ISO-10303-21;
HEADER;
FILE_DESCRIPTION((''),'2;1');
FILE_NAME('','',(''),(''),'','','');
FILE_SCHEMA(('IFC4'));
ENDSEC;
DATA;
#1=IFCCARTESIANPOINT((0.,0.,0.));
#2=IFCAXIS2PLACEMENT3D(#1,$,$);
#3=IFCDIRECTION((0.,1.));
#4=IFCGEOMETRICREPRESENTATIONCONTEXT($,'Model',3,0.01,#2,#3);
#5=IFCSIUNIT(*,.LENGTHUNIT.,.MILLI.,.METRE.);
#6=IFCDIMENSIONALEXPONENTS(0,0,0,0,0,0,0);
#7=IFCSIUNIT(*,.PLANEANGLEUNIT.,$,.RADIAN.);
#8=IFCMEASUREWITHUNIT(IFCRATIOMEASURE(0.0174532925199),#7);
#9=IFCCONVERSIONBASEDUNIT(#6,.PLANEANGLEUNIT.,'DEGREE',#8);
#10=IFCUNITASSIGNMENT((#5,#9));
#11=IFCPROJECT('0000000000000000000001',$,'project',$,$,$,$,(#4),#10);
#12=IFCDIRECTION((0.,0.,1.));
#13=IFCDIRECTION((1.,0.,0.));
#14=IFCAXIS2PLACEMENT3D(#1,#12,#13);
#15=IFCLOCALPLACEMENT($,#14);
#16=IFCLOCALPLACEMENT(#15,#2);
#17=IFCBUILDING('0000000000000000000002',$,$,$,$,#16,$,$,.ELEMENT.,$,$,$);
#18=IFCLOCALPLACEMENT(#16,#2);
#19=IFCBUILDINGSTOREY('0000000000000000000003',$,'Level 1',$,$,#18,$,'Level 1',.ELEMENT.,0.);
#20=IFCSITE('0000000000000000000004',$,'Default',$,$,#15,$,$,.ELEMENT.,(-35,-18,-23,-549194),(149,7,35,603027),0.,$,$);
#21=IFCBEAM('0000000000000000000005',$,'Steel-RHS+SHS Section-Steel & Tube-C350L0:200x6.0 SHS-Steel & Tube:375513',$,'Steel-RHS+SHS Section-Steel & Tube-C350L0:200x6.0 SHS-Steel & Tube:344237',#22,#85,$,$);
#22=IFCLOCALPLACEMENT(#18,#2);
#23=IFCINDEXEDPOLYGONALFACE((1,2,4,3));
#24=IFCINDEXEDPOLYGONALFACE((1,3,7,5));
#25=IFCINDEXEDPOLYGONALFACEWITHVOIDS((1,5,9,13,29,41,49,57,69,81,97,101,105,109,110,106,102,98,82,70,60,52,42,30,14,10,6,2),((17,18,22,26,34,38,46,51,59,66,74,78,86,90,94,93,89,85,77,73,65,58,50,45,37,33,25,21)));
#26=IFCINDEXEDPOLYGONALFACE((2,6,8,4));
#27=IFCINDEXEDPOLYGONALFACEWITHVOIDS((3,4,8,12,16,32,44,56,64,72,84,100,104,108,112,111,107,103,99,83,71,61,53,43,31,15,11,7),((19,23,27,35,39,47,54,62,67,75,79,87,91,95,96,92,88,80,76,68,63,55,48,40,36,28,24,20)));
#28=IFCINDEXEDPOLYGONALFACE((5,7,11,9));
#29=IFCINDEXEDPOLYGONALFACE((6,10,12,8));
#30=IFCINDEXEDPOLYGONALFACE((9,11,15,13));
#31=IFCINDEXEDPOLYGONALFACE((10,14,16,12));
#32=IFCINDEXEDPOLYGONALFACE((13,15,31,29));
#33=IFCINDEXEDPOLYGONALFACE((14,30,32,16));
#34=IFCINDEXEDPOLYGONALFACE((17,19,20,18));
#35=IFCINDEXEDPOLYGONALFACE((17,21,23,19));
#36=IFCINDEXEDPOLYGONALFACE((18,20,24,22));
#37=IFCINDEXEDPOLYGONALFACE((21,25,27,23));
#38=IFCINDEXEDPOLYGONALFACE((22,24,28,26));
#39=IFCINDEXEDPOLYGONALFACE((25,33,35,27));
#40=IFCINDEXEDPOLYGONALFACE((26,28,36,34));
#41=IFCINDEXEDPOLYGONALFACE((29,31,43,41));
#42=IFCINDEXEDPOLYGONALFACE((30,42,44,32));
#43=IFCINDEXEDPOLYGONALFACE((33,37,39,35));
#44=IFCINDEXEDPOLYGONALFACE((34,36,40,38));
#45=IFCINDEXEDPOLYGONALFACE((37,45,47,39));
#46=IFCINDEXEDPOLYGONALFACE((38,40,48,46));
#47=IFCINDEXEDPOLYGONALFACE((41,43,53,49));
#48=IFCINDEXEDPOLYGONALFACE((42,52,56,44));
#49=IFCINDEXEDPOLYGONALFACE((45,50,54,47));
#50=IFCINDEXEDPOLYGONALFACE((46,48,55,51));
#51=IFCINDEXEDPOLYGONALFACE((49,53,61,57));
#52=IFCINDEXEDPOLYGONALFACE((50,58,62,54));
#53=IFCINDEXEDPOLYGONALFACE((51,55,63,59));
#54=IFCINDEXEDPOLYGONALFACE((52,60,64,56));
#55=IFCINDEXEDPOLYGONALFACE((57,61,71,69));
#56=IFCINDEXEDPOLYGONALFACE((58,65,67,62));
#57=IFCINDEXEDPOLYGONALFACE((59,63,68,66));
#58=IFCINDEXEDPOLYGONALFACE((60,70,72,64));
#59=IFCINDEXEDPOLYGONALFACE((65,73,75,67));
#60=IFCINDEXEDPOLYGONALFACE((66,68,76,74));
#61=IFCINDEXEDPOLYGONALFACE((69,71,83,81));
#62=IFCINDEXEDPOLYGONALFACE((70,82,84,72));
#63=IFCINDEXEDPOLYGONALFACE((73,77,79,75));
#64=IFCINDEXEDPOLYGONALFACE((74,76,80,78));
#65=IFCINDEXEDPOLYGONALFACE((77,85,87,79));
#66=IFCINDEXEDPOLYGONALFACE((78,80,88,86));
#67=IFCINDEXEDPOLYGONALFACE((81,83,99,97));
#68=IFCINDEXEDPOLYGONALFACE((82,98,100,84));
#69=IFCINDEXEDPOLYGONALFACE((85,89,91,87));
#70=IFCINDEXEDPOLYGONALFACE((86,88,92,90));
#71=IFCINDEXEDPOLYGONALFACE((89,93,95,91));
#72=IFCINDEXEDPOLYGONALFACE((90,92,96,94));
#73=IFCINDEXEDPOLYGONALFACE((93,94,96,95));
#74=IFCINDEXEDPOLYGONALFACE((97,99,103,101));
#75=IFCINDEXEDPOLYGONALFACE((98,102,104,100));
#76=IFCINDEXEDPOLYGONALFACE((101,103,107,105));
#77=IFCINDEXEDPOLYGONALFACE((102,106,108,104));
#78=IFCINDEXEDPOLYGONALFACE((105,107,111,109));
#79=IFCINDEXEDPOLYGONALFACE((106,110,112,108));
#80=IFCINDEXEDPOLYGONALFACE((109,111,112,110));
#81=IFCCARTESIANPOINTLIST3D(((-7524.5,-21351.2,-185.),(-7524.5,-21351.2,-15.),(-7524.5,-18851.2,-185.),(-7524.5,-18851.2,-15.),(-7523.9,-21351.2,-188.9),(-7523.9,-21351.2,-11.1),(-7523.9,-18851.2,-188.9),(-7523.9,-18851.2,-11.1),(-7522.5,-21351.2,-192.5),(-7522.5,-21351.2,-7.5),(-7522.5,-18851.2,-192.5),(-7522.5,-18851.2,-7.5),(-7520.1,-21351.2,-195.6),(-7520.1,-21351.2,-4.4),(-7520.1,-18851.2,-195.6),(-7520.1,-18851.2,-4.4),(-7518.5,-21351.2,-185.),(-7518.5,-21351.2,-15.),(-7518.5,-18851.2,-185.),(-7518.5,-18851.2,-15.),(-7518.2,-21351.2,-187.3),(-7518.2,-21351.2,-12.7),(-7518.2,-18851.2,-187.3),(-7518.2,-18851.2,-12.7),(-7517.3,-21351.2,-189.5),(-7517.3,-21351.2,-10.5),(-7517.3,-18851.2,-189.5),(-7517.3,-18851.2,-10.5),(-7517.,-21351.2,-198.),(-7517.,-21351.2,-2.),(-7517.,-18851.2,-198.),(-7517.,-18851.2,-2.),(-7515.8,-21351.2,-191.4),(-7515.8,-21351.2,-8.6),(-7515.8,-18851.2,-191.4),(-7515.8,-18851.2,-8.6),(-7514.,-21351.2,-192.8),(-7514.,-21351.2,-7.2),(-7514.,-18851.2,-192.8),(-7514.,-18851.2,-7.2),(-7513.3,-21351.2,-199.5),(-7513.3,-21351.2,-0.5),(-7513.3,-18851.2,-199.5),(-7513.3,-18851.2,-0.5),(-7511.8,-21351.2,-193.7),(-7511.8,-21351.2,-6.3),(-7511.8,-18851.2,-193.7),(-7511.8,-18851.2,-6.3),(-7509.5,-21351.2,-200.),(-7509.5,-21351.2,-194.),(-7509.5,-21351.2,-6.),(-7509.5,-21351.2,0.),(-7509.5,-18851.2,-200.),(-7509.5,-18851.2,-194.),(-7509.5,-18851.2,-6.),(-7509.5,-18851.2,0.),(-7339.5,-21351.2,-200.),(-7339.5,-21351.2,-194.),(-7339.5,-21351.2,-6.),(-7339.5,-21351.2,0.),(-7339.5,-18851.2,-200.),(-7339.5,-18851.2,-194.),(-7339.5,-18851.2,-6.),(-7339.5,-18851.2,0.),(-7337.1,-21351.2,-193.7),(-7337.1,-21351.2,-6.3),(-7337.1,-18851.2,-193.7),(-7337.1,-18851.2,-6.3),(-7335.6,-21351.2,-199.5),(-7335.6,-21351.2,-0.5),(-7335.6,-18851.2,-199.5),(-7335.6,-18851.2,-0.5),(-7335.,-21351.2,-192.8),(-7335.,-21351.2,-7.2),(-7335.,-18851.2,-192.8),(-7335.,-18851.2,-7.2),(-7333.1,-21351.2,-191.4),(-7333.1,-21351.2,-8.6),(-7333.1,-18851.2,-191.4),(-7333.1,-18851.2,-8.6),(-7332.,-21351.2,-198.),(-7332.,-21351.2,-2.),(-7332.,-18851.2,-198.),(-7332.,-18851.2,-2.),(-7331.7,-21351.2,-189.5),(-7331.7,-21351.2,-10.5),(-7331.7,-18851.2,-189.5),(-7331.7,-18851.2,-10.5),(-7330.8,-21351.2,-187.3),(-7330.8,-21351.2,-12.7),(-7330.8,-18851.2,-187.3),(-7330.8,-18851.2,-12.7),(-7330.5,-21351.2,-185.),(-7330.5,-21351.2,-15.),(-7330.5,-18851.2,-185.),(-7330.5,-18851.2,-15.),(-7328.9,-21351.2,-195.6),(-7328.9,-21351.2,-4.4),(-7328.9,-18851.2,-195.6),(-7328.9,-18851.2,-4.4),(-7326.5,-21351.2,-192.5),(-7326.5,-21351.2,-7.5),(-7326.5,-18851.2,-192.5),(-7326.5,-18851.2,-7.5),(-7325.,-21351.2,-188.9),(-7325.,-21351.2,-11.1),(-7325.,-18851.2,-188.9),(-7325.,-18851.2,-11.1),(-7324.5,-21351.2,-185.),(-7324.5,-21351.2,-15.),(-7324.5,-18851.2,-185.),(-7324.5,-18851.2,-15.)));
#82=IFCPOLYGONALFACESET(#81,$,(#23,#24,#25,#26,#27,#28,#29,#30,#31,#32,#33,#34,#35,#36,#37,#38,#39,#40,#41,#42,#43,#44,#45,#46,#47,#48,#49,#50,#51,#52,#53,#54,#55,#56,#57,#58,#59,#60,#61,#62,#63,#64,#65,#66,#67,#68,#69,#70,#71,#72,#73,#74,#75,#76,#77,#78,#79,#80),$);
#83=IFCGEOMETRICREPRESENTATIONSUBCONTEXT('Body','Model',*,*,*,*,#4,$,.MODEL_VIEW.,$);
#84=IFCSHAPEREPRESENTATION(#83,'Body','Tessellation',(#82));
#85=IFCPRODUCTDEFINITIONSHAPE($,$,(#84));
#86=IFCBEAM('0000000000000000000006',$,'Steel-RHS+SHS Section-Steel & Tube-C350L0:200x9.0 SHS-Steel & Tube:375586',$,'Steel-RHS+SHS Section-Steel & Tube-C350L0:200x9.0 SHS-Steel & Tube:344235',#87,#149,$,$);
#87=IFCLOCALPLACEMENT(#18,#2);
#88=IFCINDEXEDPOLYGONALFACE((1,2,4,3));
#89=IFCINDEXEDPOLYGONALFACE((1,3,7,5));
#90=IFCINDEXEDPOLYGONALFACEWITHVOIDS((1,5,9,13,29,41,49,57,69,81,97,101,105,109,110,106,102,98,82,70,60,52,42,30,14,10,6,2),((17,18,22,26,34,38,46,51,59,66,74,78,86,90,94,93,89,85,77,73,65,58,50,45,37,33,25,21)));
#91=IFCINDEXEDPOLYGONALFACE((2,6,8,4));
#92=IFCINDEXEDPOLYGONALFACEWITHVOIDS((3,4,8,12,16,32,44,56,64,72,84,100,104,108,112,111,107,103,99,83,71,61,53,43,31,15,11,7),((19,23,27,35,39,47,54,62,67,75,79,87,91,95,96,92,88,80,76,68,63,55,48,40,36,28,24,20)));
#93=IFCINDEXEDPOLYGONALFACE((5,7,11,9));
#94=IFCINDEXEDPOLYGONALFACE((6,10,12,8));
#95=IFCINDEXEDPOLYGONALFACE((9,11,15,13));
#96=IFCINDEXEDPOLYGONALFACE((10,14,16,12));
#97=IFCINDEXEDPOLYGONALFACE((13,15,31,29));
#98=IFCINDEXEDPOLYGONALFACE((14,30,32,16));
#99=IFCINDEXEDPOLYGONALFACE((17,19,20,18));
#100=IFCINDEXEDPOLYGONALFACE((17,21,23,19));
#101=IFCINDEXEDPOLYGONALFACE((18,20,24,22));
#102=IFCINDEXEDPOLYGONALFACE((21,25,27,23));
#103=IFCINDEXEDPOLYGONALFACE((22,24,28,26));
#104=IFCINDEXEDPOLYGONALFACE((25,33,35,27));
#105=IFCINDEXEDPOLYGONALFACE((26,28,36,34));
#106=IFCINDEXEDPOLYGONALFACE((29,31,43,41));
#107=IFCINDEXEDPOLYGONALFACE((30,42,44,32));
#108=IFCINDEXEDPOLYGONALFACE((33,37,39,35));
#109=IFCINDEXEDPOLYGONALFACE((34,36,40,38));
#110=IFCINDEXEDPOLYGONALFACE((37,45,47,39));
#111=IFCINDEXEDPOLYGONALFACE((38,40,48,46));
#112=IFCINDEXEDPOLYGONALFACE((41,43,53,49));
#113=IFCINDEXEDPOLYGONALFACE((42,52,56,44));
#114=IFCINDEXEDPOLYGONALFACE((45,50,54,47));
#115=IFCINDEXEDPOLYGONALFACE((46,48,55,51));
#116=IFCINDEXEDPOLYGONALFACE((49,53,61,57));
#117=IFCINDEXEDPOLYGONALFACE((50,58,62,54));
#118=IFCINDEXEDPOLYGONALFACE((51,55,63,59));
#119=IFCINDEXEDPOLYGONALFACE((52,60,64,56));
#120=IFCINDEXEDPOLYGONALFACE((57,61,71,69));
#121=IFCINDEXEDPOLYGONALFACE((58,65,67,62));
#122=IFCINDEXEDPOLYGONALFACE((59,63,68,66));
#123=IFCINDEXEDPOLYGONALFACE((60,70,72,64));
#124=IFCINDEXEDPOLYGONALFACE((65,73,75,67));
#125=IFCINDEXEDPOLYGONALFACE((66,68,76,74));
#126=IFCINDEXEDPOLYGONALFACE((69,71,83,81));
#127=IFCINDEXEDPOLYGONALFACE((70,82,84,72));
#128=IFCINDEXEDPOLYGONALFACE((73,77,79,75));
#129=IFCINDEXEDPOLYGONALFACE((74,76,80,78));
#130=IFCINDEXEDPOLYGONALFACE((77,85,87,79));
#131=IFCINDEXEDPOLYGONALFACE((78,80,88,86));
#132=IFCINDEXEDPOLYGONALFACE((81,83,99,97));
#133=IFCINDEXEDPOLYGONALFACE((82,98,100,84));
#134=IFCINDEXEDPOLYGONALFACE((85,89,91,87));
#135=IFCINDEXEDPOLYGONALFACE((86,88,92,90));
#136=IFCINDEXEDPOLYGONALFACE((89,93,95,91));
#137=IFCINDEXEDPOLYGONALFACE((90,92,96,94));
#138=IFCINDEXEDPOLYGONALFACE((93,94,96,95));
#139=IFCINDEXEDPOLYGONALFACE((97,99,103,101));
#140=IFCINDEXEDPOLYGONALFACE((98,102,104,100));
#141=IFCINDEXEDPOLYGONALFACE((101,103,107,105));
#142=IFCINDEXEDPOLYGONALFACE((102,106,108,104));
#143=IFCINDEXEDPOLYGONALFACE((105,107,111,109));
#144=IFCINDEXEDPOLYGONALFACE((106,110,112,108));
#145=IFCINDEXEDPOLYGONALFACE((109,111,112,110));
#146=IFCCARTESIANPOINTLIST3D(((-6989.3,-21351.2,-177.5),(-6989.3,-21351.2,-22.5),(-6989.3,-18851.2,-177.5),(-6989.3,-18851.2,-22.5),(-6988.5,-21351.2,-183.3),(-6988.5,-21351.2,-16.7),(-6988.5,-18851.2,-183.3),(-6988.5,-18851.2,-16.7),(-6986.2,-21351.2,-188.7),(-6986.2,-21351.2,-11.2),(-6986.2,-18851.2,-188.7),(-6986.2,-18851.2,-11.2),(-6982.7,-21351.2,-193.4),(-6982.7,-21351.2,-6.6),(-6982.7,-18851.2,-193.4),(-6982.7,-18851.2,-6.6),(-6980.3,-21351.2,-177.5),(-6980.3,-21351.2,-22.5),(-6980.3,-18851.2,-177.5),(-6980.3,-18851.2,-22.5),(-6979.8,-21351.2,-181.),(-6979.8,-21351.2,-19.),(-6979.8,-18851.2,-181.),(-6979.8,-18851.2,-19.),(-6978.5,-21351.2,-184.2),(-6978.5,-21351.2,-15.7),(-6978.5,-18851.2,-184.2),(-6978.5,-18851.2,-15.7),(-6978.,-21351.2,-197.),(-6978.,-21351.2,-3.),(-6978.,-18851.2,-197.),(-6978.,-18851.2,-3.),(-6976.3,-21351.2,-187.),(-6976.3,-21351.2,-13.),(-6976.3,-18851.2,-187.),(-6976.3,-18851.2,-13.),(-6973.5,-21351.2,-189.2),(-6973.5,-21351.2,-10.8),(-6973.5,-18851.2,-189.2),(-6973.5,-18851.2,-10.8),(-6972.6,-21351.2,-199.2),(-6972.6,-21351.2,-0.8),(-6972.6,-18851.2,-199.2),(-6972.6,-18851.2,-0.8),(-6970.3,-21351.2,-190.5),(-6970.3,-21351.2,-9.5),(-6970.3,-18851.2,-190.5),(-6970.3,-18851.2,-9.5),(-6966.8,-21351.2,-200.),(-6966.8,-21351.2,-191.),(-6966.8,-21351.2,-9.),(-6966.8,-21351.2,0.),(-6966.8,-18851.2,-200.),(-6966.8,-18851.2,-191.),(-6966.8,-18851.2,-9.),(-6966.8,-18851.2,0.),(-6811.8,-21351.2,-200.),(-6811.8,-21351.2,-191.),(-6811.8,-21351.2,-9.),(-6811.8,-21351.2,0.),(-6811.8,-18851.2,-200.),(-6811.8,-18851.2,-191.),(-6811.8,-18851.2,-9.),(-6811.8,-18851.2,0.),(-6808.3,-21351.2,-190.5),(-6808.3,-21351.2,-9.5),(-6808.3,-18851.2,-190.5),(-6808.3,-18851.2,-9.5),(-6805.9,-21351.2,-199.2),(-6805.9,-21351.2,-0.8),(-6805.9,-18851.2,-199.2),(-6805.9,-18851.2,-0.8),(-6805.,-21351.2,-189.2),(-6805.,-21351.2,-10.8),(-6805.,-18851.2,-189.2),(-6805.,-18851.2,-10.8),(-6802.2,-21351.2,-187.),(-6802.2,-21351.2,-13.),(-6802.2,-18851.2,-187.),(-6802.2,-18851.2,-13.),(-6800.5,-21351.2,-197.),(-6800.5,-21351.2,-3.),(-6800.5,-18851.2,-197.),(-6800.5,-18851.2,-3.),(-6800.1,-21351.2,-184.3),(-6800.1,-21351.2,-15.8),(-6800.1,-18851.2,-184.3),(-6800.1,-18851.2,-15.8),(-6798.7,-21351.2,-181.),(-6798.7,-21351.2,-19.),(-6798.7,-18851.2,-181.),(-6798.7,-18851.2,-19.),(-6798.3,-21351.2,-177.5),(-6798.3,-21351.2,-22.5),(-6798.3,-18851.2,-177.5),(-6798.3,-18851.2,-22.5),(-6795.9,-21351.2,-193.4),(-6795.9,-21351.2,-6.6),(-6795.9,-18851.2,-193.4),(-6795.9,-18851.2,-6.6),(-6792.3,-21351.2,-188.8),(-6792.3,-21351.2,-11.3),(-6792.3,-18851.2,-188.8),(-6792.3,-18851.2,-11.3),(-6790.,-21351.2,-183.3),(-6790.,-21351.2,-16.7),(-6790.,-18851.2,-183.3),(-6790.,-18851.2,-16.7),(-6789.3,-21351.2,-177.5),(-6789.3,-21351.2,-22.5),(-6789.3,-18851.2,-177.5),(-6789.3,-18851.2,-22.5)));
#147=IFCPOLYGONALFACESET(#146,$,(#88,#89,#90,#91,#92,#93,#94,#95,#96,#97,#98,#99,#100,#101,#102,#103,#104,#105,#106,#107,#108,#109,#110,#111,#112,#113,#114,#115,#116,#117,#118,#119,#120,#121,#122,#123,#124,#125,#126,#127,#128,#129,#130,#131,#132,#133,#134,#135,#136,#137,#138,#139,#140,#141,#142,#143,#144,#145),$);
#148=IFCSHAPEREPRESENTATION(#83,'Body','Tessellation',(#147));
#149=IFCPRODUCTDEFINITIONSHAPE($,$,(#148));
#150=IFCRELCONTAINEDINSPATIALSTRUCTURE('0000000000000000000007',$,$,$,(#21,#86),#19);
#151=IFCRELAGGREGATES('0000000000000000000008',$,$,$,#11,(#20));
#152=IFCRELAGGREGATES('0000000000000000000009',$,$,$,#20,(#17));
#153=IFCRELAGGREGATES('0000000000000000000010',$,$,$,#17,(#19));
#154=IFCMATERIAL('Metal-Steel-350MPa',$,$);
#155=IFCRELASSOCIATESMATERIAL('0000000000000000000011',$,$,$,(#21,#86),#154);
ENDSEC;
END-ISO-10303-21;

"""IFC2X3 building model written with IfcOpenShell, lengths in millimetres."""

from ifc_helpers import new_model, entity, si_unit, converted_unit, direction, frame, frame_2d, origin, origin_with_axes, place, context, subcontext, project, spatial, polyline, circle_curve, parameter, trimmed, segment, composite_curve, outline, extrude, material, element, save


model = new_model("IFC2X3")

# Units and contexts
model_context = context("Model", 3, precision=0.01, world=origin(), true_north=direction((0.0, 1.0)))
body_context = subcontext(model_context, "Body", "Model", "MODEL_VIEW")
ifc_project = project(units=[si_unit("LENGTHUNIT", "METRE", prefix="MILLI"), converted_unit("PLANEANGLEUNIT", "DEGREE", entity("IfcRatioMeasure", 0.0174532925199), si_unit("PLANEANGLEUNIT", "RADIAN"), dimensions=[0, 0, 0, 0, 0, 0, 0])], contexts=[model_context])

# Site, building, storey
site_placement = place(None, origin_with_axes())
site = spatial("IfcSite", under=ifc_project, at=site_placement, Name="Default", CompositionType="ELEMENT", RefLatitude=(-35, -18, -23, -549194), RefLongitude=(149, 7, 35, 603027), RefElevation=0.0)
building_placement = place(site_placement, origin())
building = spatial("IfcBuilding", under=site, at=building_placement, CompositionType="ELEMENT")
storey_placement = place(building_placement, origin())
storey = spatial("IfcBuildingStorey", under=building, at=storey_placement, Name="Level 1", LongName="Level 1", CompositionType="ELEMENT", Elevation=0.0)

# Beams
ifc_material = material(Name="Metal-Steel-350MPa")
beam_1_placement = place(storey_placement, frame((-7424.5, -18851.2, 0.0), z_axis=(0.0, 0.0, 1.0), x_axis=(0.0, -1.0, 0.0)))
element("IfcBeam", 1, at=beam_1_placement, inside=storey, material=ifc_material, Name="Steel-RHS+SHS Section-Steel & Tube-C350L0:200x6.0 SHS-Steel & Tube:375513", ObjectType="Steel-RHS+SHS Section-Steel & Tube-C350L0:200x6.0 SHS-Steel & Tube:344237", context=body_context, shape_type="SweptSolid", body=[
    extrude(outline(composite_curve([segment(trimmed(circle_curve(frame_2d((-85.0, -85.0), x_axis=(1.0, 0.0)), 15.0), [parameter(180.0)], [parameter(270.0)], True, "PARAMETER"), True, "CONTINUOUS"), segment(polyline([(-85.0, -100.0), (85.0, -100.0)]), True, "CONTINUOUS"), segment(trimmed(circle_curve(frame_2d((85.0, -85.0), x_axis=(1.0, 0.0)), 15.0), [parameter(270.0)], [parameter(0.0)], True, "PARAMETER"), True, "CONTINUOUS"), segment(polyline([(100.0, -85.0), (100.0, 85.0)]), True, "CONTINUOUS"), segment(trimmed(circle_curve(frame_2d((85.0, 85.0), x_axis=(1.0, 0.0)), 15.0), [parameter(0.0)], [parameter(90.0)], True, "PARAMETER"), True, "CONTINUOUS"), segment(polyline([(85.0, 100.0), (-85.0, 100.0)]), True, "CONTINUOUS"), segment(trimmed(circle_curve(frame_2d((-85.0, 85.0), x_axis=(1.0, 0.0)), 15.0), [parameter(90.0)], [parameter(180.0)], True, "PARAMETER"), True, "CONTINUOUS"), segment(polyline([(-100.0, 85.0), (-100.0, -85.0)]), True, "CONTINUOUS")], self_intersect=False), holes=[composite_curve([segment(polyline([(85.0, -94.0), (-85.0, -94.0)]), True, "CONTINUOUS"), segment(trimmed(circle_curve(frame_2d((-85.0, -85.0), x_axis=(1.0, 0.0)), 9.0), [parameter(180.0)], [parameter(270.0)], True, "PARAMETER"), False, "CONTINUOUS"), segment(polyline([(-94.0, -85.0), (-94.0, 85.0)]), True, "CONTINUOUS"), segment(trimmed(circle_curve(frame_2d((-85.0, 85.0), x_axis=(1.0, 0.0)), 9.0), [parameter(90.0)], [parameter(180.0)], True, "PARAMETER"), False, "CONTINUOUS"), segment(polyline([(-85.0, 94.0), (85.0, 94.0)]), True, "CONTINUOUS"), segment(trimmed(circle_curve(frame_2d((85.0, 85.0), x_axis=(1.0, 0.0)), 9.0), [parameter(360.0)], [parameter(90.0)], True, "PARAMETER"), False, "CONTINUOUS"), segment(polyline([(94.0, 85.0), (94.0, -85.0)]), True, "CONTINUOUS"), segment(trimmed(circle_curve(frame_2d((85.0, -85.0), x_axis=(1.0, 0.0)), 9.0), [parameter(270.0)], [parameter(0.0)], True, "PARAMETER"), False, "CONTINUOUS")], self_intersect=False)]), frame((0.0, 0.0, -100.0), z_axis=(1.0, 0.0, 0.0), x_axis=(0.0, -1.0, 0.0)), (0.0, 0.0, 1.0), 2500.0),
])
beam_2_placement = place(storey_placement, frame((-6889.3, -18851.2, 0.0), z_axis=(0.0, 0.0, 1.0), x_axis=(0.0, -1.0, 0.0)))
element("IfcBeam", 2, at=beam_2_placement, inside=storey, material=ifc_material, Name="Steel-RHS+SHS Section-Steel & Tube-C350L0:200x9.0 SHS-Steel & Tube:375586", ObjectType="Steel-RHS+SHS Section-Steel & Tube-C350L0:200x9.0 SHS-Steel & Tube:344235", context=body_context, shape_type="SweptSolid", body=[
    extrude(outline(composite_curve([segment(trimmed(circle_curve(frame_2d((-77.5, -77.5), x_axis=(1.0, 0.0)), 22.5), [parameter(180.0)], [parameter(270.0)], True, "PARAMETER"), True, "CONTINUOUS"), segment(polyline([(-77.5, -100.0), (77.5, -100.0)]), True, "CONTINUOUS"), segment(trimmed(circle_curve(frame_2d((77.5, -77.5), x_axis=(1.0, 0.0)), 22.5), [parameter(270.0)], [parameter(0.0)], True, "PARAMETER"), True, "CONTINUOUS"), segment(polyline([(100.0, -77.5), (100.0, 77.5)]), True, "CONTINUOUS"), segment(trimmed(circle_curve(frame_2d((77.5, 77.5), x_axis=(1.0, 0.0)), 22.5), [parameter(0.0)], [parameter(90.0)], True, "PARAMETER"), True, "CONTINUOUS"), segment(polyline([(77.5, 100.0), (-77.5, 100.0)]), True, "CONTINUOUS"), segment(trimmed(circle_curve(frame_2d((-77.5, 77.5), x_axis=(1.0, 0.0)), 22.5), [parameter(90.0)], [parameter(180.0)], True, "PARAMETER"), True, "CONTINUOUS"), segment(polyline([(-100.0, 77.5), (-100.0, -77.5)]), True, "CONTINUOUS")], self_intersect=False), holes=[composite_curve([segment(polyline([(77.5, -91.0), (-77.5, -91.0)]), True, "CONTINUOUS"), segment(trimmed(circle_curve(frame_2d((-77.5, -77.5), x_axis=(1.0, 0.0)), 13.5), [parameter(180.0)], [parameter(270.0)], True, "PARAMETER"), False, "CONTINUOUS"), segment(polyline([(-91.0, -77.5), (-91.0, 77.5)]), True, "CONTINUOUS"), segment(trimmed(circle_curve(frame_2d((-77.5, 77.5), x_axis=(1.0, 0.0)), 13.5), [parameter(90.0)], [parameter(180.0)], True, "PARAMETER"), False, "CONTINUOUS"), segment(polyline([(-77.5, 91.0), (77.5, 91.0)]), True, "CONTINUOUS"), segment(trimmed(circle_curve(frame_2d((77.5, 77.5), x_axis=(1.0, 0.0)), 13.5), [parameter(360.0)], [parameter(90.0)], True, "PARAMETER"), False, "CONTINUOUS"), segment(polyline([(91.0, 77.5), (91.0, -77.5)]), True, "CONTINUOUS"), segment(trimmed(circle_curve(frame_2d((77.5, -77.5), x_axis=(1.0, 0.0)), 13.5), [parameter(270.0)], [parameter(0.0)], True, "PARAMETER"), False, "CONTINUOUS")], self_intersect=False)]), frame((0.0, 0.0, -100.0), z_axis=(1.0, 0.0, 0.0), x_axis=(0.0, -1.0, 0.0)), (0.0, 0.0, 1.0), 2500.0),
])

save(model, "model.ifc")
